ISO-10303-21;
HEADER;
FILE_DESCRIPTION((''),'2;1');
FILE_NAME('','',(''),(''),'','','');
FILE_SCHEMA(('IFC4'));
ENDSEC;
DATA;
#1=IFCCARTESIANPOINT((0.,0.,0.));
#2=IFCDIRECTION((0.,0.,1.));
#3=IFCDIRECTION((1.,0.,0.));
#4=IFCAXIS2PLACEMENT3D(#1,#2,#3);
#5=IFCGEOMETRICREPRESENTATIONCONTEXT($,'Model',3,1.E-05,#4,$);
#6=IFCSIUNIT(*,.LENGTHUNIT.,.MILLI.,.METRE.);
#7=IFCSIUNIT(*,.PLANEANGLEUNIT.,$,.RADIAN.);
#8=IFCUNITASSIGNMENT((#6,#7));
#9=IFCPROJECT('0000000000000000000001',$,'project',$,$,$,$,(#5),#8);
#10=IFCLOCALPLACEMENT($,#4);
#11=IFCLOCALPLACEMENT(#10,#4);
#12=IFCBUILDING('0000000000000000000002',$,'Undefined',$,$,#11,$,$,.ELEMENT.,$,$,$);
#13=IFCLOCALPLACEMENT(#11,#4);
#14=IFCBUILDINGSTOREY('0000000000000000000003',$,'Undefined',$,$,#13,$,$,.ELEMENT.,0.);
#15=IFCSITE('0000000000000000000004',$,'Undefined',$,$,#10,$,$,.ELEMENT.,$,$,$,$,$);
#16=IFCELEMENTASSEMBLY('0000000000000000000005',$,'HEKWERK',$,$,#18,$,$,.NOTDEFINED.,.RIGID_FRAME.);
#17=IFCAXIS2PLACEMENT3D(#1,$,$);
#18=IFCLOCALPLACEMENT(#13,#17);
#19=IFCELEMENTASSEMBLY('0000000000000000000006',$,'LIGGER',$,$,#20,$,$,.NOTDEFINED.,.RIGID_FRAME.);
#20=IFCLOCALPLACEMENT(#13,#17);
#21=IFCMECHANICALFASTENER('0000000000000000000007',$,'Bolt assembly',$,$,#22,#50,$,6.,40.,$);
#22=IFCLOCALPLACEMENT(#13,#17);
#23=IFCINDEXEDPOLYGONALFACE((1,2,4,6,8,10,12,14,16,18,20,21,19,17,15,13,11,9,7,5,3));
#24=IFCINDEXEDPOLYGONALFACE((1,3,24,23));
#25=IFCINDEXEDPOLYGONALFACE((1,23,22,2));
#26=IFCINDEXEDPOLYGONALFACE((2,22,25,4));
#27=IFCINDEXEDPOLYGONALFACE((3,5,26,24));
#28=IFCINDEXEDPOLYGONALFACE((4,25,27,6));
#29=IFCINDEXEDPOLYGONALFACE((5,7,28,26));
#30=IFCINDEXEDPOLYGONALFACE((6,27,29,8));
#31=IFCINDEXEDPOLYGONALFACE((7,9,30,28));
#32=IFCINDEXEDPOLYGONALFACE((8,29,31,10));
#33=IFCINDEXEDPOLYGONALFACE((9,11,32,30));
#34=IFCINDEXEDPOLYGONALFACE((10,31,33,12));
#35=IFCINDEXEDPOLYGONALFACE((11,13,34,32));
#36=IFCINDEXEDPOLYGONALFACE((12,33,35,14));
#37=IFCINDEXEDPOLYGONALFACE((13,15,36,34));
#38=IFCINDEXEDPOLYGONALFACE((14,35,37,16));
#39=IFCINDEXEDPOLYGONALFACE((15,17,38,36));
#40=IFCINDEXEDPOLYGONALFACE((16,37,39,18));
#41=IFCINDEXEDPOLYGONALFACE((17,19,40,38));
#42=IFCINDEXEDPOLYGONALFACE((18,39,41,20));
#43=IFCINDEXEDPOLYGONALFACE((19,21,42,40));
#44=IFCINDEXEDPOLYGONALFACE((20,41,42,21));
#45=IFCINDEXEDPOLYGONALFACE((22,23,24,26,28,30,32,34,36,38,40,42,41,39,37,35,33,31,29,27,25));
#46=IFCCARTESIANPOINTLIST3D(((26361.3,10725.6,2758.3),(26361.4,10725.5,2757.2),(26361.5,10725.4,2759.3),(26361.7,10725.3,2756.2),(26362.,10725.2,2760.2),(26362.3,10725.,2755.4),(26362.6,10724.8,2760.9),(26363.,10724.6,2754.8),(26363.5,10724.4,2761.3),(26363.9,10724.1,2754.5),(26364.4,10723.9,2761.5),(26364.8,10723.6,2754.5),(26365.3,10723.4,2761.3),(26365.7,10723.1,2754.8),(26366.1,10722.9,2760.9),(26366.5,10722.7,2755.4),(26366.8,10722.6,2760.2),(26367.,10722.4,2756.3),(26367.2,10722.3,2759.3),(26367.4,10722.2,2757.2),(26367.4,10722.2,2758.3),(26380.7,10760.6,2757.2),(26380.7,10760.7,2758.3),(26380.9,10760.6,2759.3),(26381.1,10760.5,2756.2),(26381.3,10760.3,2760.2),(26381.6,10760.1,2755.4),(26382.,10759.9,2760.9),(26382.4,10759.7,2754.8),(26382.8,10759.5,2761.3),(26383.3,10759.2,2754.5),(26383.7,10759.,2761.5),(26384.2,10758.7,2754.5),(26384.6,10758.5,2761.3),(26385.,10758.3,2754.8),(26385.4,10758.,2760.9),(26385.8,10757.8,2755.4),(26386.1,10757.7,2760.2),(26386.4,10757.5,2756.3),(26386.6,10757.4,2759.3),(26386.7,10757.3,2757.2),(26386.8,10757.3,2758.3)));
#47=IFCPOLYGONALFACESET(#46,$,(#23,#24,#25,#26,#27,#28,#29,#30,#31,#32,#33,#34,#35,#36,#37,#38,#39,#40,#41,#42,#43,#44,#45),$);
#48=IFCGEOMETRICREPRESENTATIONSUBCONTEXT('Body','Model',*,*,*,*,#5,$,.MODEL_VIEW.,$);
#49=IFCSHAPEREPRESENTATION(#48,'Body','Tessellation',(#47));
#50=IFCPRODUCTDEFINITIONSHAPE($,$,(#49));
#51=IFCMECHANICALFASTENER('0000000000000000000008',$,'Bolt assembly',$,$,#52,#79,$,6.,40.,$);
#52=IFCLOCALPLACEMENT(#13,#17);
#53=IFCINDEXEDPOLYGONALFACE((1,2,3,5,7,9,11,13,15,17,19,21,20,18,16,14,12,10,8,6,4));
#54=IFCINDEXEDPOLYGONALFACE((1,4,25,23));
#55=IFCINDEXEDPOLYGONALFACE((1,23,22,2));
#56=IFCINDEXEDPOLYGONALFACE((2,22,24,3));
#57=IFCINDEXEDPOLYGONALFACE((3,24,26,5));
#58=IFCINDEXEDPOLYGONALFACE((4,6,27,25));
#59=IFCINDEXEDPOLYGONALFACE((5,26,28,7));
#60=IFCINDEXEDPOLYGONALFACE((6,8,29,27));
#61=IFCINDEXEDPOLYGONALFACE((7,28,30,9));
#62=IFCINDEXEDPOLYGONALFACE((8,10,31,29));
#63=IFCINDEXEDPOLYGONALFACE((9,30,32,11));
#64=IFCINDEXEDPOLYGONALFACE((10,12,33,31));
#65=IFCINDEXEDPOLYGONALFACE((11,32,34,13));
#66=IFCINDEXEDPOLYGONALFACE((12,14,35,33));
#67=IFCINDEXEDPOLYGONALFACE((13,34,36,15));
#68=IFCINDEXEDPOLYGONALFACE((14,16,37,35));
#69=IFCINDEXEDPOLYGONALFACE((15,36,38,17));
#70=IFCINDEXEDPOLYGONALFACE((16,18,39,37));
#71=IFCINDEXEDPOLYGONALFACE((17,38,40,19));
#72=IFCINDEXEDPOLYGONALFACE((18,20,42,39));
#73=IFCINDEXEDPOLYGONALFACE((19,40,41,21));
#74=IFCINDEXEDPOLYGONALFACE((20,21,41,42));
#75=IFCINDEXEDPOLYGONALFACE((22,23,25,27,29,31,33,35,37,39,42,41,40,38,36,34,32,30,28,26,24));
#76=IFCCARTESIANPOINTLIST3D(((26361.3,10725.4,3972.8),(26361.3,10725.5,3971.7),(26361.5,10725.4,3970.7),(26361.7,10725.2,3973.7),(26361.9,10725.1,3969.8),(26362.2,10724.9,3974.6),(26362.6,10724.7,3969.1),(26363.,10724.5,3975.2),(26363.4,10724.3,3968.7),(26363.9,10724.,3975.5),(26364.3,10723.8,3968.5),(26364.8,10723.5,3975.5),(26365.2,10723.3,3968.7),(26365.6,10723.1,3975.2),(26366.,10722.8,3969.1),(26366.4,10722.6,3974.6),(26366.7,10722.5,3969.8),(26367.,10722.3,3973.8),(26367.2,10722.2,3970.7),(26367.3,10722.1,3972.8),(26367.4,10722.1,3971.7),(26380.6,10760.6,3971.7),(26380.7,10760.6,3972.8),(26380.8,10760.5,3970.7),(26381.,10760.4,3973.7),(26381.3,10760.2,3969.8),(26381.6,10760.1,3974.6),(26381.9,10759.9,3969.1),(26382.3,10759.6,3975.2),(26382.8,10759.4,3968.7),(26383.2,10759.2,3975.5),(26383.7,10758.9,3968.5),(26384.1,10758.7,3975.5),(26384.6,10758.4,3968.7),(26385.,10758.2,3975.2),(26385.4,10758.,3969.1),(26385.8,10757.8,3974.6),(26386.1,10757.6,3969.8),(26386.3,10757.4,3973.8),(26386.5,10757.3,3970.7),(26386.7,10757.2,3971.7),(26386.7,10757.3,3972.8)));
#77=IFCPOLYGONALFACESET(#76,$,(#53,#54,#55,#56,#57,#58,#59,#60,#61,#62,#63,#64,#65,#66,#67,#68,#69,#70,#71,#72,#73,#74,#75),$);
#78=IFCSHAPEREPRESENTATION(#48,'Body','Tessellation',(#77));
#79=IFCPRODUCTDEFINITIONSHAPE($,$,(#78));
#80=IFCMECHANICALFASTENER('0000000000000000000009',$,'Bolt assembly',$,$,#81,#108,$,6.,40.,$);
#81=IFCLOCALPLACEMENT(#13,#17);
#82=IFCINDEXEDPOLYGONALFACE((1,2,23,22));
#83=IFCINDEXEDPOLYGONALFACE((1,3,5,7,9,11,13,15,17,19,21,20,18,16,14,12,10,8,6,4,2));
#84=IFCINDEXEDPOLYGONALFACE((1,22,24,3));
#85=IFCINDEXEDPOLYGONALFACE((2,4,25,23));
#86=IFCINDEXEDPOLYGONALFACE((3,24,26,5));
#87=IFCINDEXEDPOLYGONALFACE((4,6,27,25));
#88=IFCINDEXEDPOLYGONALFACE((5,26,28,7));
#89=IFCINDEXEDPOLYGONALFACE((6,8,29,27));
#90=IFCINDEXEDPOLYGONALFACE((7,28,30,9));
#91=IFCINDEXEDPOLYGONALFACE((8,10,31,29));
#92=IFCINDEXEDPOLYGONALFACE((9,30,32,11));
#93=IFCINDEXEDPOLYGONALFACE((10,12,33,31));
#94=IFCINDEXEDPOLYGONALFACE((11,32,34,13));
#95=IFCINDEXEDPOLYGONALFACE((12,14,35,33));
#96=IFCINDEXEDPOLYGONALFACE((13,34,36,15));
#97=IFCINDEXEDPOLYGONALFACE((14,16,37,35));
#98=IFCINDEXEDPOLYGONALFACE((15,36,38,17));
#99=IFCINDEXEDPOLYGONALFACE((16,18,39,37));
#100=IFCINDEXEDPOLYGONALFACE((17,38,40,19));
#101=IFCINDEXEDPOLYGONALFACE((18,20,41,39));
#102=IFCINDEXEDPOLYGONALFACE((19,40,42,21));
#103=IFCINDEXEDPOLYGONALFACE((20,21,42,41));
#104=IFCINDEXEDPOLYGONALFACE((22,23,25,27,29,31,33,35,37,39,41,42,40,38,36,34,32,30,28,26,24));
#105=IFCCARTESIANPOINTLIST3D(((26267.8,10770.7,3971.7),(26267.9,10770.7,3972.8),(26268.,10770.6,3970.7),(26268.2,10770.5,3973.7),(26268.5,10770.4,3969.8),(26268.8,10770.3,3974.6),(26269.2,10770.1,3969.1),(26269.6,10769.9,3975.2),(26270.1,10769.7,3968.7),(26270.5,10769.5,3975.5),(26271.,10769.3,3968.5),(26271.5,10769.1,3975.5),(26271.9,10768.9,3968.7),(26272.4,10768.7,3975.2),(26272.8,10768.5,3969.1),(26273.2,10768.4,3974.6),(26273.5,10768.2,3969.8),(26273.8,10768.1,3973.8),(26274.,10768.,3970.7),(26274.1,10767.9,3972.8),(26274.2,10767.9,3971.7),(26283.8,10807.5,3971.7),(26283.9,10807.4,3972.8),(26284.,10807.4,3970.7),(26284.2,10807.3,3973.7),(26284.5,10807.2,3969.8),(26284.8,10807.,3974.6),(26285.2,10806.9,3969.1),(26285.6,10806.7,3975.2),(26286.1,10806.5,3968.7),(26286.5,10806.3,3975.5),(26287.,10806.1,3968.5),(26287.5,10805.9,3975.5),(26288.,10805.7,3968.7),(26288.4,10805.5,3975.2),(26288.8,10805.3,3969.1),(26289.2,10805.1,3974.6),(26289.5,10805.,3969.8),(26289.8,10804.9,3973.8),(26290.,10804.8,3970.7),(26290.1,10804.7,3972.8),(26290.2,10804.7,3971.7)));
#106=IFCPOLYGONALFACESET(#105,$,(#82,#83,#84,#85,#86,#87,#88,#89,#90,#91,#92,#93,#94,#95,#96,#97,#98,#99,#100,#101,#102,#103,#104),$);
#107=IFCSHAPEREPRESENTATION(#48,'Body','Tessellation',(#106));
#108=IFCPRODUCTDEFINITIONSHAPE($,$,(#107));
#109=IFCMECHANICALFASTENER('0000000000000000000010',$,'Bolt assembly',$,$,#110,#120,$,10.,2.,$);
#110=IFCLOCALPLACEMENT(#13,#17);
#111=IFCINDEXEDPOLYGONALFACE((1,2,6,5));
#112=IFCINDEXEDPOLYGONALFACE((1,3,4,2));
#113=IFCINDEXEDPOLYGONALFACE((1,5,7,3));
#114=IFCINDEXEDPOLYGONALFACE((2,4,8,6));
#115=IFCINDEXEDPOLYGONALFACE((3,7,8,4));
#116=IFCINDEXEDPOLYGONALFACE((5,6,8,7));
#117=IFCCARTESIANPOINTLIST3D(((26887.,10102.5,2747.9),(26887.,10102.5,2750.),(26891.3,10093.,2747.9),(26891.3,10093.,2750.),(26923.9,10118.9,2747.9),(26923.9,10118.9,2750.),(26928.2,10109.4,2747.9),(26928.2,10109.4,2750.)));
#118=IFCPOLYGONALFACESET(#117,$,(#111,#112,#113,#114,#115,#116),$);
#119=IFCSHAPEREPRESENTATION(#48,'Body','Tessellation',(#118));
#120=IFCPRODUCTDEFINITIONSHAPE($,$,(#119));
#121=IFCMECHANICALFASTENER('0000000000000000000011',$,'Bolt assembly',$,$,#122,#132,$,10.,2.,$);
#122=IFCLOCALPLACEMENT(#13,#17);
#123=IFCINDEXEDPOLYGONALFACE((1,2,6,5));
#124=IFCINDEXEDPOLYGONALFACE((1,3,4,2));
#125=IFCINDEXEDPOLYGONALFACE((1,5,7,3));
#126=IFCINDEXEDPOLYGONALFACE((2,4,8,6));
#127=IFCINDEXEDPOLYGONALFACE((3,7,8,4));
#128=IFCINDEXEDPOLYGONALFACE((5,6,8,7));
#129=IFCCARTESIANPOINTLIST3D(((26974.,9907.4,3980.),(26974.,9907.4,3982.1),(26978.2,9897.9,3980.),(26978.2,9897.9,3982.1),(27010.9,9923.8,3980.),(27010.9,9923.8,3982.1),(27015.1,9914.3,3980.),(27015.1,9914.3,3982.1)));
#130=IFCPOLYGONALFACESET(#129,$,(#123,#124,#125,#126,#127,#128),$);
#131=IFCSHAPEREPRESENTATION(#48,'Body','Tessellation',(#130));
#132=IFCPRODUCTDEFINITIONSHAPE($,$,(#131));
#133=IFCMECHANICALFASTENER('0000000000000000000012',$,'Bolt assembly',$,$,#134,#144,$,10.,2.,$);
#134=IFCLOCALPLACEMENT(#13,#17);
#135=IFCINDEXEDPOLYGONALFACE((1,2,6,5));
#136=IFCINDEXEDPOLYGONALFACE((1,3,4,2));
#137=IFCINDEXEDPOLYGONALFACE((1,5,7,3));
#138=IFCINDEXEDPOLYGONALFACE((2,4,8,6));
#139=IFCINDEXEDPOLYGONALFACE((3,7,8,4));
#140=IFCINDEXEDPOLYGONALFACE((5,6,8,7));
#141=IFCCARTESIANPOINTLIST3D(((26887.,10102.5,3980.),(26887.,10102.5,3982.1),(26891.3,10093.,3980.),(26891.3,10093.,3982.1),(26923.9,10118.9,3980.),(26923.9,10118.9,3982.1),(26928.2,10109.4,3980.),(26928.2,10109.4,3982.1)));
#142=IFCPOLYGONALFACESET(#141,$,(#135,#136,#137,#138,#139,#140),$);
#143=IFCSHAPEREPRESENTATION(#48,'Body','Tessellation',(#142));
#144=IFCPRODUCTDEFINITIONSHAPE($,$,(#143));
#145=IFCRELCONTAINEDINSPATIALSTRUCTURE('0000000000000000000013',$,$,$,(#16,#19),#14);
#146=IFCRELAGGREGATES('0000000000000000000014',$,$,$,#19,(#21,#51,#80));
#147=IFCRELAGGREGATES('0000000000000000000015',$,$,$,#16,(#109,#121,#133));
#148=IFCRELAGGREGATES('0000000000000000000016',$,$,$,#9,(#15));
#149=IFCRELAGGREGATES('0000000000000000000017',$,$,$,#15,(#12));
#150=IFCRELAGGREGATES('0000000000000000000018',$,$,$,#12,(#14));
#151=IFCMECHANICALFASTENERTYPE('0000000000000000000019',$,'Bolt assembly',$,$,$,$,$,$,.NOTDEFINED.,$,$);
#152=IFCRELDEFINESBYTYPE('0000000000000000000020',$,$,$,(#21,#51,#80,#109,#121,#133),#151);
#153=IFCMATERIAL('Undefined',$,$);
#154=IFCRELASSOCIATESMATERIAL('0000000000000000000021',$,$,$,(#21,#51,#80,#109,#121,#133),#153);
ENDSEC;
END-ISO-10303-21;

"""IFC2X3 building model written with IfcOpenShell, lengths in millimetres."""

from ifc_helpers import new_model, si_unit, frame, origin_with_axes, origin_2d_with_axis, place, context, subcontext, project, spatial, polyline, segment, composite_curve, circle, outline, extrude, source, transform, mapped, material, type_object, element, aggregate, save


model = new_model("IFC2X3")

# Units and contexts
model_context = context("Model", 3, precision=1e-05, world=origin_with_axes())
body_context = subcontext(model_context, "Body", "Model", "MODEL_VIEW")
ifc_project = project(units=[si_unit("LENGTHUNIT", "METRE", prefix="MILLI"), si_unit("PLANEANGLEUNIT", "RADIAN")], contexts=[model_context])

# Site, building, storey
site_placement = place(None, origin_with_axes())
site = spatial("IfcSite", under=ifc_project, at=site_placement, Name="Undefined", CompositionType="ELEMENT")
building_placement = place(site_placement, origin_with_axes())
building = spatial("IfcBuilding", under=site, at=building_placement, Name="Undefined", CompositionType="ELEMENT")
storey_placement = place(building_placement, origin_with_axes())
storey = spatial("IfcBuildingStorey", under=building, at=storey_placement, Name="Undefined", CompositionType="ELEMENT", Elevation=0.0)

# Element assemblies
assembly_1_placement = place(storey_placement, origin_with_axes())
assembly_1 = element("IfcElementAssembly", 1, at=assembly_1_placement, inside=storey, Name="HEKWERK", AssemblyPlace="NOTDEFINED", PredefinedType="RIGID_FRAME")
assembly_2_placement = place(storey_placement, origin_with_axes())
assembly_2 = element("IfcElementAssembly", 2, at=assembly_2_placement, inside=storey, Name="LIGGER", AssemblyPlace="NOTDEFINED", PredefinedType="RIGID_FRAME")

# Mechanical fasteners
ifc_material_1 = material(Name="Undefined")
mechanical_fastener_type = type_object("IfcMechanicalFastenerType", Name="Bolt assembly")
shared_shape_1 = source(origin_with_axes(), body_context, "Body", "SweptSolid", [
    extrude(circle(Radius=3.5, at=origin_2d_with_axis()), frame((0.0, -18.1, 0.0), z_axis=(0.0, 1.0, 0.0), x_axis=(1.0, 0.0, 0.0)), (0.0, 0.0, 1.0), 40.1),
])
mechanical_fastener_1_placement = place(assembly_2_placement, frame((26373.1, 10739.7, 2758.0), z_axis=(-0.875834, 0.482612, 0.0), x_axis=(0.0, 0.0, 1.0)))
mechanical_fastener_1 = element("IfcMechanicalFastener", 3, at=mechanical_fastener_1_placement, type_object=mechanical_fastener_type, material=ifc_material_1, Name="Bolt assembly", NominalDiameter=6.0, NominalLength=40.0, context=body_context, shape_type="MappedRepresentation", body=[
    mapped(shared_shape_1, transform((0.0, 0.0, 0.0))),
])
shared_shape_2 = source(origin_with_axes(), body_context, "Body", "SweptSolid", [
    extrude(circle(Radius=3.5, at=origin_2d_with_axis()), frame((0.0, -21.9, 0.0), z_axis=(0.0, 1.0, 0.0), x_axis=(1.0, 0.0, 0.0)), (0.0, 0.0, 1.0), 40.1),
])
mechanical_fastener_2_placement = place(assembly_2_placement, frame((26373.1, 10739.7, 3972.0), z_axis=(-0.875834, 0.482612, 0.0), x_axis=(0.0, 0.0, -1.0)))
mechanical_fastener_2 = element("IfcMechanicalFastener", 4, at=mechanical_fastener_2_placement, type_object=mechanical_fastener_type, material=ifc_material_1, Name="Bolt assembly", NominalDiameter=6.0, NominalLength=40.0, context=body_context, shape_type="MappedRepresentation", body=[
    mapped(shared_shape_2, transform((0.0, 0.0, 0.0))),
])
shared_shape_3 = source(origin_with_axes(), body_context, "Body", "SweptSolid", [
    extrude(circle(Radius=3.5, at=origin_2d_with_axis()), frame((0.0, -21.5, 0.0), z_axis=(0.0, 1.0, 0.0), x_axis=(1.0, 0.0, 0.0)), (0.0, 0.0, 1.0), 40.1),
])
mechanical_fastener_3_placement = place(assembly_2_placement, frame((26278.4, 10786.4, 3972.0), z_axis=(-0.916877, 0.399169, 0.0), x_axis=(0.0, 0.0, -1.0)))
mechanical_fastener_3 = element("IfcMechanicalFastener", 5, at=mechanical_fastener_3_placement, type_object=mechanical_fastener_type, material=ifc_material_1, Name="Bolt assembly", NominalDiameter=6.0, NominalLength=40.0, context=body_context, shape_type="MappedRepresentation", body=[
    mapped(shared_shape_3, transform((0.0, 0.0, 0.0))),
])
aggregate(assembly_2, [mechanical_fastener_1, mechanical_fastener_2, mechanical_fastener_3])
shared_shape_4 = source(origin_with_axes(), body_context, "Body", "SweptSolid", [
    extrude(outline(composite_curve([segment(polyline([(-20.2, 5.2), (20.2, 5.2)]), True, "CONTINUOUS"), segment(polyline([(20.2, 5.2), (20.2, -5.2)]), True, "CONTINUOUS"), segment(polyline([(20.2, -5.2), (-20.2, -5.2)]), True, "CONTINUOUS"), segment(polyline([(-20.2, -5.2), (-20.2, 5.2)]), True, "CONTINUOUS")], self_intersect=False)), frame((0.0, -1.0, 0.0), z_axis=(0.0, 1.0, 0.0), x_axis=(1.0, 0.0, 0.0)), (0.0, 0.0, 1.0), 2.1),
])
mechanical_fastener_4_placement = place(assembly_1_placement, frame((26907.6, 10105.9, 2749.0), z_axis=(0.406594, -0.913609, 0.0), x_axis=(-0.913609, -0.406594, 0.0)))
mechanical_fastener_4 = element("IfcMechanicalFastener", 6, at=mechanical_fastener_4_placement, type_object=mechanical_fastener_type, material=ifc_material_1, Name="Bolt assembly", NominalDiameter=10.0, NominalLength=2.0, context=body_context, shape_type="MappedRepresentation", body=[
    mapped(shared_shape_4, transform((0.0, 0.0, 0.0))),
])
shared_shape_5 = source(origin_with_axes(), body_context, "Body", "SweptSolid", [
    extrude(outline(composite_curve([segment(polyline([(-20.2, 5.2), (20.2, 5.2)]), True, "CONTINUOUS"), segment(polyline([(20.2, 5.2), (20.2, -5.2)]), True, "CONTINUOUS"), segment(polyline([(20.2, -5.2), (-20.2, -5.2)]), True, "CONTINUOUS"), segment(polyline([(-20.2, -5.2), (-20.2, 5.2)]), True, "CONTINUOUS")], self_intersect=False)), frame((0.0, -1.0, 0.0), z_axis=(0.0, 1.0, 0.0), x_axis=(1.0, 0.0, 0.0)), (0.0, 0.0, 1.0), 2.1),
])
mechanical_fastener_5_placement = place(assembly_1_placement, frame((26994.6, 9910.9, 3981.0), z_axis=(-0.406594, 0.913609, 0.0), x_axis=(-0.913609, -0.406594, 0.0)))
mechanical_fastener_5 = element("IfcMechanicalFastener", 7, at=mechanical_fastener_5_placement, type_object=mechanical_fastener_type, material=ifc_material_1, Name="Bolt assembly", NominalDiameter=10.0, NominalLength=2.0, context=body_context, shape_type="MappedRepresentation", body=[
    mapped(shared_shape_5, transform((0.0, 0.0, 0.0))),
])
shared_shape_6 = source(origin_with_axes(), body_context, "Body", "SweptSolid", [
    extrude(outline(composite_curve([segment(polyline([(-20.2, 5.2), (20.2, 5.2)]), True, "CONTINUOUS"), segment(polyline([(20.2, 5.2), (20.2, -5.2)]), True, "CONTINUOUS"), segment(polyline([(20.2, -5.2), (-20.2, -5.2)]), True, "CONTINUOUS"), segment(polyline([(-20.2, -5.2), (-20.2, 5.2)]), True, "CONTINUOUS")], self_intersect=False)), frame((0.0, -1.0, 0.0), z_axis=(0.0, 1.0, 0.0), x_axis=(1.0, 0.0, 0.0)), (0.0, 0.0, 1.0), 2.1),
])
mechanical_fastener_6_placement = place(assembly_1_placement, frame((26907.6, 10105.9, 3981.0), z_axis=(-0.406594, 0.913609, 0.0), x_axis=(-0.913609, -0.406594, 0.0)))
mechanical_fastener_6 = element("IfcMechanicalFastener", 8, at=mechanical_fastener_6_placement, type_object=mechanical_fastener_type, material=ifc_material_1, Name="Bolt assembly", NominalDiameter=10.0, NominalLength=2.0, context=body_context, shape_type="MappedRepresentation", body=[
    mapped(shared_shape_6, transform((0.0, 0.0, 0.0))),
])
aggregate(assembly_1, [mechanical_fastener_4, mechanical_fastener_5, mechanical_fastener_6])

save(model, "model.ifc")
